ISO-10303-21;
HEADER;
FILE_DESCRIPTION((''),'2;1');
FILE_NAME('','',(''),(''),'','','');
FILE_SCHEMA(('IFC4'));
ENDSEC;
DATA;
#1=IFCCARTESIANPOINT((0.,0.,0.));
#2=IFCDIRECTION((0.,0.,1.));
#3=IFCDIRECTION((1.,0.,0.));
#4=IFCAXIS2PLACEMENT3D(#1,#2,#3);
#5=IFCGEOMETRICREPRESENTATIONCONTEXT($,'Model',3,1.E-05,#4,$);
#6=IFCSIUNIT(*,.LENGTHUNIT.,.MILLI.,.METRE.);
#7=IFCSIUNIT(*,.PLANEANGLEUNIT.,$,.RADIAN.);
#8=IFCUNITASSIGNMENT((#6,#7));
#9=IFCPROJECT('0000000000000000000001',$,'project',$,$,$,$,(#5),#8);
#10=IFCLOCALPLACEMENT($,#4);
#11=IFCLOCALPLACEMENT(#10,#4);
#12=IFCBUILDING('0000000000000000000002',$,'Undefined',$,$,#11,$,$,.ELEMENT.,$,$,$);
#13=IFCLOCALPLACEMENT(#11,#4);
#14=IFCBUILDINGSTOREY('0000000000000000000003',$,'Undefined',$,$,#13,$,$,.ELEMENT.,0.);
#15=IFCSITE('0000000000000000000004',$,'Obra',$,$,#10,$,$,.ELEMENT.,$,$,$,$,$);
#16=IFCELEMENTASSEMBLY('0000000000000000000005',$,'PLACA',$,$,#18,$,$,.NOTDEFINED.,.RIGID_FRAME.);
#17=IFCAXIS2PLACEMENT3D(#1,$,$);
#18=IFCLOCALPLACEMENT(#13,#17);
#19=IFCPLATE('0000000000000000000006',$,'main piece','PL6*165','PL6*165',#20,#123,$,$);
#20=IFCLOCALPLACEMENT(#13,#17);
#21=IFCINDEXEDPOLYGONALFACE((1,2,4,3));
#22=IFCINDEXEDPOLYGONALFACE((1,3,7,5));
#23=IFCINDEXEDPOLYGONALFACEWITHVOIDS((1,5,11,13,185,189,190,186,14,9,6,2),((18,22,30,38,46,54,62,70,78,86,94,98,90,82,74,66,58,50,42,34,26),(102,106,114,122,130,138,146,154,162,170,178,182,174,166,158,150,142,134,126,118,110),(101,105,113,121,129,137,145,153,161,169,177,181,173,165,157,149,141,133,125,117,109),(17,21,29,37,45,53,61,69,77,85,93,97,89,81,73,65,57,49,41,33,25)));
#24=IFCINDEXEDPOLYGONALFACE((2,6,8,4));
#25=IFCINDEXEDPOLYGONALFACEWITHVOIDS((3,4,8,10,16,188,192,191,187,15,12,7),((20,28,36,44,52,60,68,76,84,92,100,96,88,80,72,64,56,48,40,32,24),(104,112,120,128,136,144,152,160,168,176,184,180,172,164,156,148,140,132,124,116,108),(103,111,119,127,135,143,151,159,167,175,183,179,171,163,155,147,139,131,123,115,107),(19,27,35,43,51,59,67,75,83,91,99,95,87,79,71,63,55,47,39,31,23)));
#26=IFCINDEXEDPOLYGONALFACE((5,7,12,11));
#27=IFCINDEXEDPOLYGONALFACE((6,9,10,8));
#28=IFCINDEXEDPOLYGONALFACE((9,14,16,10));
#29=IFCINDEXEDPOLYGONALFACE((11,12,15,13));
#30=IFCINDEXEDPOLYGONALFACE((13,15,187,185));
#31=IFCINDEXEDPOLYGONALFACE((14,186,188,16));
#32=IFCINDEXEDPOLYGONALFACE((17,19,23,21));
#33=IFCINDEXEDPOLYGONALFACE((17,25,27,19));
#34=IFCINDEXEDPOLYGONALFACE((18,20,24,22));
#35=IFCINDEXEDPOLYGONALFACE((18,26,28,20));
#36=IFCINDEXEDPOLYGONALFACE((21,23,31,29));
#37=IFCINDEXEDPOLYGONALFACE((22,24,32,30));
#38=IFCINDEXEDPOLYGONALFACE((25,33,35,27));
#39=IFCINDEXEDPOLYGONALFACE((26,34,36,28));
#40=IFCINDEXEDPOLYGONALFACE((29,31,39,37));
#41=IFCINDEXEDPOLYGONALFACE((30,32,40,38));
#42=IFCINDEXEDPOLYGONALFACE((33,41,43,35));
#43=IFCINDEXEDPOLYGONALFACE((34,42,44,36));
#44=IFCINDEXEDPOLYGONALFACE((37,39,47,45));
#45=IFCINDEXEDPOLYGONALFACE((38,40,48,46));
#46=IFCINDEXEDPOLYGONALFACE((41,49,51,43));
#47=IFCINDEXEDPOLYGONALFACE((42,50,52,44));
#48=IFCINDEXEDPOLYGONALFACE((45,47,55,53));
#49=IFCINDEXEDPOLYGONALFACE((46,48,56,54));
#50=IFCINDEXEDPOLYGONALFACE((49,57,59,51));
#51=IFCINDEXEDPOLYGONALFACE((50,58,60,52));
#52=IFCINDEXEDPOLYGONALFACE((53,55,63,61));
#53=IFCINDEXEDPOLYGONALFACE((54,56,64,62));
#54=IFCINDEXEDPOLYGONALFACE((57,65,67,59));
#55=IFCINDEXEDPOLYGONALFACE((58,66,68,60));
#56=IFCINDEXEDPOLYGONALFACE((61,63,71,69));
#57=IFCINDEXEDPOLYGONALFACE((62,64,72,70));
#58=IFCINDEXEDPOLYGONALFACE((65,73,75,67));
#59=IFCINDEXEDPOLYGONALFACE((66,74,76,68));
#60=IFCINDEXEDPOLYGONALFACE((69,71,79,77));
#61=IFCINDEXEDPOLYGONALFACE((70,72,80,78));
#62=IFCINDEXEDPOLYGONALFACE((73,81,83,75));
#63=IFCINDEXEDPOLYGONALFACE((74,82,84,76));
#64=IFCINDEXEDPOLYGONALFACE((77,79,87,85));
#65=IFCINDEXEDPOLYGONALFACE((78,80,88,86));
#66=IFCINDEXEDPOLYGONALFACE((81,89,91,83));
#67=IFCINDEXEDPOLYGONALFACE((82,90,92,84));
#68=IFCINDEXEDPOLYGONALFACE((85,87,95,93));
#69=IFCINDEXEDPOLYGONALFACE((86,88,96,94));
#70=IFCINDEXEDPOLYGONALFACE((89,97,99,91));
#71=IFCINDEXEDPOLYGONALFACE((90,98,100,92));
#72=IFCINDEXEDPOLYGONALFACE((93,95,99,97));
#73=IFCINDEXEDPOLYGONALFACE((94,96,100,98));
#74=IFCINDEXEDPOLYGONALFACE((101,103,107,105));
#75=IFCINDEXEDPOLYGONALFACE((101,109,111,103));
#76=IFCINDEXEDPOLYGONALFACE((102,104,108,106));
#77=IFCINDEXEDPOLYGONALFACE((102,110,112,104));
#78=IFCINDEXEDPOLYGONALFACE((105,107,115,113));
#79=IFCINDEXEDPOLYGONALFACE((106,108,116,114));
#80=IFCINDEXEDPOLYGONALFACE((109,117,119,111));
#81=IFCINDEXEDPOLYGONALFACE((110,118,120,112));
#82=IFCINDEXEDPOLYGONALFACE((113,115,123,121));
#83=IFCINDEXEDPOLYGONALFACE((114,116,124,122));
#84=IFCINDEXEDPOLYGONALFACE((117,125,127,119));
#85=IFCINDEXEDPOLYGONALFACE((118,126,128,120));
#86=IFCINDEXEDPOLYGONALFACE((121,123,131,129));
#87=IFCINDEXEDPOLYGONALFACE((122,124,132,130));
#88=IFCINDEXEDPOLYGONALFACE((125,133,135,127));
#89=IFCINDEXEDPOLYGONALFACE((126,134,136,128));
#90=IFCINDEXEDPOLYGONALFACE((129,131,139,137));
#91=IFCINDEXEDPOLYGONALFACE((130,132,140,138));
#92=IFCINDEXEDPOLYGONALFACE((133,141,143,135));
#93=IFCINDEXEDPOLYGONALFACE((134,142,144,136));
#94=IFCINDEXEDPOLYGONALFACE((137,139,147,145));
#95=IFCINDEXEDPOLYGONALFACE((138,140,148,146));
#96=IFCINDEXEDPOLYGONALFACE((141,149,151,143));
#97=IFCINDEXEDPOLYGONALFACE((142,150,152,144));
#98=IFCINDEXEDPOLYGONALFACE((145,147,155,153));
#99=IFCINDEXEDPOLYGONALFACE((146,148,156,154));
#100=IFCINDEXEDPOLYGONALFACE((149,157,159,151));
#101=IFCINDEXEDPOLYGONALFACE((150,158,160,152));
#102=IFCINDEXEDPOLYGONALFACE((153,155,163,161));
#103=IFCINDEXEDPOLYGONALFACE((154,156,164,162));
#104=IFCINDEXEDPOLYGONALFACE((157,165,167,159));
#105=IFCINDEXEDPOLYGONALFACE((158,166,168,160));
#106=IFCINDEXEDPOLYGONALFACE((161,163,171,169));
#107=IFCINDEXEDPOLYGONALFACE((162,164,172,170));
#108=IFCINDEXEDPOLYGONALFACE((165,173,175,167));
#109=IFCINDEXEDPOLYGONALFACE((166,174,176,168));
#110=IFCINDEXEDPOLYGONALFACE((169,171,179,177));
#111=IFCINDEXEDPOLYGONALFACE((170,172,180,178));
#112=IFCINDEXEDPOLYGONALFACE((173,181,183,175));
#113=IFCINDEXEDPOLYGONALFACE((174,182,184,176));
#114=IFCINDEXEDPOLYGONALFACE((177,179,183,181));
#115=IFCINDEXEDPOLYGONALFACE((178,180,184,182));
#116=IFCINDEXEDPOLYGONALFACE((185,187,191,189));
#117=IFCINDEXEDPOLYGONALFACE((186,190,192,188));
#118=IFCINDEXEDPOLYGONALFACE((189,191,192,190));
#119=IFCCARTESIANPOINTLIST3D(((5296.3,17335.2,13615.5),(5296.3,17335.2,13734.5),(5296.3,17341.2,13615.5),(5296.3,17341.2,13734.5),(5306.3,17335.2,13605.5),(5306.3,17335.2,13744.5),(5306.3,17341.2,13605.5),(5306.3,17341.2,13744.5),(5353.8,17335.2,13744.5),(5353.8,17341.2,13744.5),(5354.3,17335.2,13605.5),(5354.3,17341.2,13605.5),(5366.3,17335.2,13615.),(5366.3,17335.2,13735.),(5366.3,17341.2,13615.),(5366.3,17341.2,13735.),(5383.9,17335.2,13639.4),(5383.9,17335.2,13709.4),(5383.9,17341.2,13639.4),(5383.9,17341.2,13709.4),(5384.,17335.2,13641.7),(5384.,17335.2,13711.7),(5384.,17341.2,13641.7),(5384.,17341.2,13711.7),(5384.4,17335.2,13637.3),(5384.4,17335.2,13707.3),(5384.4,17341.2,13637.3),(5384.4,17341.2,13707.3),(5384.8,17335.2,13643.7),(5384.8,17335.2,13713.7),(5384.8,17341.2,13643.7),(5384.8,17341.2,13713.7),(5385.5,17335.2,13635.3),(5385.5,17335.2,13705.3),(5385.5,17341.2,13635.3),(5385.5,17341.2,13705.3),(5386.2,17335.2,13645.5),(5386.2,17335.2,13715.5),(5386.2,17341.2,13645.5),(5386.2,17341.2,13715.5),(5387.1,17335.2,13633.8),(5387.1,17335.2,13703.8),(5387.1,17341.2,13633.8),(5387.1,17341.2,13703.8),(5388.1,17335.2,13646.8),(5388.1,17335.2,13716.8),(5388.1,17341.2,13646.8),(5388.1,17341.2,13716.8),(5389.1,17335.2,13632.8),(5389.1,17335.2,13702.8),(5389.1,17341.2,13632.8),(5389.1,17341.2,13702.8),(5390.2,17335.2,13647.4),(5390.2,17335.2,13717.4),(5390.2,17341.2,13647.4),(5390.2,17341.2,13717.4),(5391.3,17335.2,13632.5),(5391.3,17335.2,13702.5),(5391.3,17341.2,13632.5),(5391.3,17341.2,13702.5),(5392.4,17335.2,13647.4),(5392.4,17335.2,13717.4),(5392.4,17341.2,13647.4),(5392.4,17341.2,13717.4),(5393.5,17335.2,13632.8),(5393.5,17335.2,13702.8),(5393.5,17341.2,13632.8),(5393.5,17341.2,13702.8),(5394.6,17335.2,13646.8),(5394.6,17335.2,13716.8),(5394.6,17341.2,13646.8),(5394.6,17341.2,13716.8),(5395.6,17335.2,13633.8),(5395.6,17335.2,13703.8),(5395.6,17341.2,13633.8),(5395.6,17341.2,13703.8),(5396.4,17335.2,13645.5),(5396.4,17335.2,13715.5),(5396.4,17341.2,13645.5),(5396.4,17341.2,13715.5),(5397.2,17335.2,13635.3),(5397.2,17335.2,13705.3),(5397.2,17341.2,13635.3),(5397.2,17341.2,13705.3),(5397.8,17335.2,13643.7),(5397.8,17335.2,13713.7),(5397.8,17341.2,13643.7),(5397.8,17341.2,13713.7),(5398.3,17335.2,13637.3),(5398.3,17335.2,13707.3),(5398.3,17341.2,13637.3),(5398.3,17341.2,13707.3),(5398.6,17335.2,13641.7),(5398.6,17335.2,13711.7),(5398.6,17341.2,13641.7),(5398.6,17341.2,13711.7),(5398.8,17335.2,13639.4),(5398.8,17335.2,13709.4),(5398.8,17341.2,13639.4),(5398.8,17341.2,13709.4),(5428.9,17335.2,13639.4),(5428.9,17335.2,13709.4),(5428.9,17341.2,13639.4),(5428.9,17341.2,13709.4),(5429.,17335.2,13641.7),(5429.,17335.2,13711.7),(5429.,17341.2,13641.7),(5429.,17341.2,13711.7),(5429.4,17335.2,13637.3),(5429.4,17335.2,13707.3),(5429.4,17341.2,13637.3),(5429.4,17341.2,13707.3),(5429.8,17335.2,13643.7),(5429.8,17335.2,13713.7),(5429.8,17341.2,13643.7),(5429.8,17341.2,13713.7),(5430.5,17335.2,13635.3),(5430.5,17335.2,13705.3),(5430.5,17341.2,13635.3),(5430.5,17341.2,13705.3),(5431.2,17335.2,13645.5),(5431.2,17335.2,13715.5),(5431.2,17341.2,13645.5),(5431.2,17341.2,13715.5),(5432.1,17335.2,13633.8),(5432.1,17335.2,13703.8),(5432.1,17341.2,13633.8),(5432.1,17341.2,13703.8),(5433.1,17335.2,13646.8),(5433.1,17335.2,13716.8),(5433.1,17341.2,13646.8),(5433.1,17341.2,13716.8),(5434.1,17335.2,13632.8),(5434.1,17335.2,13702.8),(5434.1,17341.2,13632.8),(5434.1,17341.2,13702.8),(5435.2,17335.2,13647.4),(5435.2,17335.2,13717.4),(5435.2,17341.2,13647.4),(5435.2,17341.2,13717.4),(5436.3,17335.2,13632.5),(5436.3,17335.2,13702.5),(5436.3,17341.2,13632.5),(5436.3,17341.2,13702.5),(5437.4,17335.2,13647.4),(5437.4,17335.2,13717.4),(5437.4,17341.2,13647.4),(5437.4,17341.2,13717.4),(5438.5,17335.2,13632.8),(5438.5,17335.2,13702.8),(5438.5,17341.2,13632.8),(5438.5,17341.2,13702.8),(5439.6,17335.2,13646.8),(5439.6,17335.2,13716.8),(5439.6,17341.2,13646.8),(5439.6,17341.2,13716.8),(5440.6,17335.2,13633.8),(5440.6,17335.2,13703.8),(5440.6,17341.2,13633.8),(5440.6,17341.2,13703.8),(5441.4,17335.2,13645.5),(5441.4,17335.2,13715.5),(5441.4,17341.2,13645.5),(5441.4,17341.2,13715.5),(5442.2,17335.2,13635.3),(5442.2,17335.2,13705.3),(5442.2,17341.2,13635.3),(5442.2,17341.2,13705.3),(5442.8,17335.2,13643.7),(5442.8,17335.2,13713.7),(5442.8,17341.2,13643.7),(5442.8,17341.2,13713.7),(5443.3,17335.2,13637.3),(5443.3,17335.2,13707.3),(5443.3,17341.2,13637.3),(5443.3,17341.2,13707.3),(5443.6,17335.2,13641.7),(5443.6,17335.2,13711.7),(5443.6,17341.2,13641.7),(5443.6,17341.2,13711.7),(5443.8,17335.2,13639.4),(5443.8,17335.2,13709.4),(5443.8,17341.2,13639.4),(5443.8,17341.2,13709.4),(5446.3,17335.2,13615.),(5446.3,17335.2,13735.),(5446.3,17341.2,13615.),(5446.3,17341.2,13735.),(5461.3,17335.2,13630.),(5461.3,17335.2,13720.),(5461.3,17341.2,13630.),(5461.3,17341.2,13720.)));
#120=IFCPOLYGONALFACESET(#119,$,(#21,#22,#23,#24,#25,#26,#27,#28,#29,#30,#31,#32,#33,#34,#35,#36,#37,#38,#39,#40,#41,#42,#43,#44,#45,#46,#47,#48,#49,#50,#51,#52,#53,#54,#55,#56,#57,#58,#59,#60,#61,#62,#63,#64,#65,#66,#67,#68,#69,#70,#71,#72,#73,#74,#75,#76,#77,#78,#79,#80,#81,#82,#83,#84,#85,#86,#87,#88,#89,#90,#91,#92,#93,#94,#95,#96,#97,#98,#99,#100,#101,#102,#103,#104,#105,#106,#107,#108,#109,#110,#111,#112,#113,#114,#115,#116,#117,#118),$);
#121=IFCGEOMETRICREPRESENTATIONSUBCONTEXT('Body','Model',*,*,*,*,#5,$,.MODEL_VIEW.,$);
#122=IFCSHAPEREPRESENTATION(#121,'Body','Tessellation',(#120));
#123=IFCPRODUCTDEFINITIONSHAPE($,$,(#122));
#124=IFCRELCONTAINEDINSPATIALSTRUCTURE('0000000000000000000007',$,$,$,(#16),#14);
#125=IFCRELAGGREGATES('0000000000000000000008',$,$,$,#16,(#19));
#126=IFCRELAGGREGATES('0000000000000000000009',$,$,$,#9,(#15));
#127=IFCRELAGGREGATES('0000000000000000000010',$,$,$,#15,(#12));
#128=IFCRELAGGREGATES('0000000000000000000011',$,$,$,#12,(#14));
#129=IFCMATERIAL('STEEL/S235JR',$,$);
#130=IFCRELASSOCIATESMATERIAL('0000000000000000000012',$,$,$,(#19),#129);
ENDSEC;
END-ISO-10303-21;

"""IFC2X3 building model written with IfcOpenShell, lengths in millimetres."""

from ifc_helpers import new_model, si_unit, frame, origin_with_axes, origin_2d_with_axis, place, context, subcontext, project, spatial, polyline, circle, outline, extrude, source, transform, mapped, material, element, aggregate, save


model = new_model("IFC2X3")

# Units and contexts
model_context = context("Model", 3, precision=1e-05, world=origin_with_axes())
body_context = subcontext(model_context, "Body", "Model", "MODEL_VIEW")
ifc_project = project(units=[si_unit("LENGTHUNIT", "METRE", prefix="MILLI"), si_unit("PLANEANGLEUNIT", "RADIAN")], contexts=[model_context])

# Site, building, storey
site_placement = place(None, origin_with_axes())
site = spatial("IfcSite", under=ifc_project, at=site_placement, Name="Obra", CompositionType="ELEMENT")
building_placement = place(site_placement, origin_with_axes())
building = spatial("IfcBuilding", under=site, at=building_placement, Name="Undefined", CompositionType="ELEMENT")
storey_placement = place(building_placement, origin_with_axes())
storey = spatial("IfcBuildingStorey", under=building, at=storey_placement, Name="Undefined", CompositionType="ELEMENT", Elevation=0.0)

# Shared definitions
ifc_material_1 = material(Name="STEEL/S235JR")

# Element assembly, plate, opening
assembly_1_placement = place(storey_placement, origin_with_axes())
assembly_1 = element("IfcElementAssembly", 1, at=assembly_1_placement, inside=storey, Name="PLACA", AssemblyPlace="NOTDEFINED", PredefinedType="RIGID_FRAME")
plate_1_placement = place(assembly_1_placement, frame((5296.3, 17338.2, 13615.5), z_axis=(0.0, -1.0, 0.0), x_axis=(0.707107, 0.0, -0.707107)))
plate_1 = element("IfcPlate", 2, at=plate_1_placement, material=ifc_material_1, Name="main piece", Description="PL6*165", ObjectType="PL6*165", context=body_context, shape_type="SweptSolid", body=[
    extrude(outline(polyline([(0.0, 0.0), (14.1, 0.0), (48.1, 33.9), (49.9, 49.1), (106.4, 105.7), (106.4, 126.9), (42.8, 190.6), (21.6, 190.6), (-35.0, 134.0), (-50.6, 131.9), (-84.1, 98.3), (-84.1, 84.1), (0.0, 0.0)])), frame((0.0, 0.0, -3.0), z_axis=(0.0, 0.0, 1.0), x_axis=(1.0, 0.0, 0.0)), (0.0, 0.0, 1.0), 6.0),
])
shared_shape_1 = source(origin_with_axes(), body_context, "Body", "SweptSolid", [
    extrude(circle(Radius=7.5, at=origin_2d_with_axis()), frame((0.0, 2.4, 0.0), z_axis=(0.0, 1.0, 0.0), x_axis=(1.0, 0.0, 0.0)), (0.0, 0.0, 1.0), 6.2),
])
opening_1_placement = place(assembly_1_placement, frame((5413.8, 17332.7, 13710.0), z_axis=(1.0, 0.0, 0.0), x_axis=(0.0, 0.0, -1.0)))
element("IfcOpeningElement", 3, at=opening_1_placement, cuts=plate_1, ObjectType="Opening", context=body_context, shape_type="MappedRepresentation", body=[
    mapped(shared_shape_1, transform((0.0, 0.0, -22.5))),
    mapped(shared_shape_1, transform((70.0, 0.0, -22.5))),
    mapped(shared_shape_1, transform((0.0, 0.0, 22.5))),
    mapped(shared_shape_1, transform((70.0, 0.0, 22.5))),
])
aggregate(assembly_1, [plate_1])

save(model, "model.ifc")
